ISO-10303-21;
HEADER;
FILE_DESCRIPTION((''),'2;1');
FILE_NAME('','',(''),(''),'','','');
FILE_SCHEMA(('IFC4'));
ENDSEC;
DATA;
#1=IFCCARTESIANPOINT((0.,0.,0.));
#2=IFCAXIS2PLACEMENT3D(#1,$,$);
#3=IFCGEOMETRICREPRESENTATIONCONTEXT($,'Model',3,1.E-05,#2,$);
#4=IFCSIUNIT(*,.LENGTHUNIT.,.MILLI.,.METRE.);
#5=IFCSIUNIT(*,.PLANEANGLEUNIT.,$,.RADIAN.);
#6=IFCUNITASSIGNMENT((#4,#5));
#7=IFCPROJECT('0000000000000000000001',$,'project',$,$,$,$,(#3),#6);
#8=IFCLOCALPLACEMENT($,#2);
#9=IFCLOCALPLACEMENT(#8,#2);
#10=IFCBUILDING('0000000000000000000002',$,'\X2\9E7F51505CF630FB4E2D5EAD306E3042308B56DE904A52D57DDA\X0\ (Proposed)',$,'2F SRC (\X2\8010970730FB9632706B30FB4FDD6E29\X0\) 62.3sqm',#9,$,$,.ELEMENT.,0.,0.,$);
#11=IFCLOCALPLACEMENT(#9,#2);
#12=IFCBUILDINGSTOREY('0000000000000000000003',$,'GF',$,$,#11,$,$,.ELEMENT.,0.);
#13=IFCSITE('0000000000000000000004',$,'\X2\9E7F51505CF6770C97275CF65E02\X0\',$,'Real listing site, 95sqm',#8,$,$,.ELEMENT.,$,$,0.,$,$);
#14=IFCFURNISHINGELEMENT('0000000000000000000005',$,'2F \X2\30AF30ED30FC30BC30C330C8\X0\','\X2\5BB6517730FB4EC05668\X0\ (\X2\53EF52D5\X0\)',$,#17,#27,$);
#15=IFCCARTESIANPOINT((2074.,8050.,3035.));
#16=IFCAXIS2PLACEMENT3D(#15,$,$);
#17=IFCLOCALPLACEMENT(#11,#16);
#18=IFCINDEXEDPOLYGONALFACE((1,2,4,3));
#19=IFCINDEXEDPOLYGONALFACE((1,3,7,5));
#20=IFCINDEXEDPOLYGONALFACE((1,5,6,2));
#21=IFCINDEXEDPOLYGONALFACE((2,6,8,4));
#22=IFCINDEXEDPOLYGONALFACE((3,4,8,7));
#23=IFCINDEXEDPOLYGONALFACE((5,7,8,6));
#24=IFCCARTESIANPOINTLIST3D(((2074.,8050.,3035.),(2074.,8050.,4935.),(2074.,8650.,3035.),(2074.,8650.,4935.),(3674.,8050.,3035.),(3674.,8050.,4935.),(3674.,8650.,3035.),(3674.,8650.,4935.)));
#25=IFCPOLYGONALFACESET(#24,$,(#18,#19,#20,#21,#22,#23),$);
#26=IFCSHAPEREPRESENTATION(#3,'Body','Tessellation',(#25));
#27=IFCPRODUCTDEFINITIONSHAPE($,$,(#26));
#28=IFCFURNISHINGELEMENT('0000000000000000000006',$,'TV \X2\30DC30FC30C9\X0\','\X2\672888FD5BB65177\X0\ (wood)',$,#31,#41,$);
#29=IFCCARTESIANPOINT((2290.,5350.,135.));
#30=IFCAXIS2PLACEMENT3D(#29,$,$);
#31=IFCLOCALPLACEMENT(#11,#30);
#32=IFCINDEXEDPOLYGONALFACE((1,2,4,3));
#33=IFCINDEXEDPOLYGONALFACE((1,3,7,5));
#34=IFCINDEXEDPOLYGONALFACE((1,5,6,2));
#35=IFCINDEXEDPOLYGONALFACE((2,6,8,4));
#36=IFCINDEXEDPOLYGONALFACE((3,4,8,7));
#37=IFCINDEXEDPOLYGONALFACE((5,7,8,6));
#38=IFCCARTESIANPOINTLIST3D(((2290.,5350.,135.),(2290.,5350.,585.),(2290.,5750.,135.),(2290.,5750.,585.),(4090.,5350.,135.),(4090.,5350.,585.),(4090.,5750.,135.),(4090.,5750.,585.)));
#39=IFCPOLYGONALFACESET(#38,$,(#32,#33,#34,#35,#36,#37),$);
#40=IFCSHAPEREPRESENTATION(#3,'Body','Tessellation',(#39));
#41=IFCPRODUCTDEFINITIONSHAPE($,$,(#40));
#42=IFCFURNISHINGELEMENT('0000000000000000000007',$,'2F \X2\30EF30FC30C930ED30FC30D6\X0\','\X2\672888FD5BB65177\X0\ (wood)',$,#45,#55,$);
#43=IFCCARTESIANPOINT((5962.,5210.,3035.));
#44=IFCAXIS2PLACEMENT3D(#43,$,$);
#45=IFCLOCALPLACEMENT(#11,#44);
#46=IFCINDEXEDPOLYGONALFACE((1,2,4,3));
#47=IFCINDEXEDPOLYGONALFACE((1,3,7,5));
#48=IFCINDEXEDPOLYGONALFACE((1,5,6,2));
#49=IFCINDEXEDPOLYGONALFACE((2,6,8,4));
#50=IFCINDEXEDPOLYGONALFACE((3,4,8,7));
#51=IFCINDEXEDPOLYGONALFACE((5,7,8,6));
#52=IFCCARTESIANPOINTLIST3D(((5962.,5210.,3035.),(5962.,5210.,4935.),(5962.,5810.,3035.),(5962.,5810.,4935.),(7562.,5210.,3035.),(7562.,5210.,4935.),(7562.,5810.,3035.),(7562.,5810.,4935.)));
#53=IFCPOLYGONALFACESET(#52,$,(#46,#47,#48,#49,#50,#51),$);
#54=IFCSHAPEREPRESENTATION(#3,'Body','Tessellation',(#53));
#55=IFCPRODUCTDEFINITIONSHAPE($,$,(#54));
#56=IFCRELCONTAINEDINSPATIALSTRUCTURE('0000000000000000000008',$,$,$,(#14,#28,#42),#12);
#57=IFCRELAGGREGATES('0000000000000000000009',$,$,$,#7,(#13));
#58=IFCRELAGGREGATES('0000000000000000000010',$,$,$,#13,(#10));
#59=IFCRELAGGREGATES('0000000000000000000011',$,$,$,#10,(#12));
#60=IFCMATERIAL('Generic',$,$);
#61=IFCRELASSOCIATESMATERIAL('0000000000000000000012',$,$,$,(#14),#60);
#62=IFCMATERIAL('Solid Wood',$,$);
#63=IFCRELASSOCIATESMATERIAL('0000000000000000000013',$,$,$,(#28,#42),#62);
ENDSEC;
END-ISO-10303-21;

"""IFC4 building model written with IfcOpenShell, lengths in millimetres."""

from ifc_helpers import new_model, si_unit, frame, frame_2d, origin, place, context, project, spatial, rectangle, extrude, material, element, save


model = new_model("IFC4")

# Units and contexts
model_context = context("Model", 3, precision=1e-05, world=origin())
ifc_project = project(units=[si_unit("LENGTHUNIT", "METRE", prefix="MILLI"), si_unit("PLANEANGLEUNIT", "RADIAN")], contexts=[model_context])

# Site, building, storey
site_placement = place(None, origin())
site = spatial("IfcSite", under=ifc_project, at=site_placement, Name="鹿児島県霧島市", ObjectType="Real listing site, 95sqm", CompositionType="ELEMENT", RefElevation=0.0)
building_placement = place(site_placement, origin())
building = spatial("IfcBuilding", under=site, at=building_placement, Name="鹿児島・中庭のある回遊動線 (Proposed)", ObjectType="2F SRC (耐震・防火・保温) 62.3sqm", CompositionType="ELEMENT", ElevationOfRefHeight=0.0, ElevationOfTerrain=0.0)
storey_placement = place(building_placement, origin())
storey = spatial("IfcBuildingStorey", under=building, at=storey_placement, Name="GF", CompositionType="ELEMENT", Elevation=0.0)

# Shared definitions
ifc_material_1 = material(Name="Solid Wood")

# Shared definitions
ifc_material_2 = material(Name="Generic")

# Furnishing elements
furnishing_1_placement = place(storey_placement, frame((2074.0, 8050.0, 3035.0)))
element("IfcFurnishingElement", 1, at=furnishing_1_placement, inside=storey, material=ifc_material_2, Name="2F クローゼット", Description="家具・什器 (可動)", context=model_context, shape_type="SweptSolid", body=[
    extrude(rectangle(XDim=1600.0, YDim=600.0, at=frame_2d((800.0, 300.0))), frame((2074.0, 8050.0, 3035.0)), (0.0, 0.0, 1.0), 1900.0),
])
furnishing_2_placement = place(storey_placement, frame((2290.0, 5350.0, 135.0)))
element("IfcFurnishingElement", 2, at=furnishing_2_placement, inside=storey, material=ifc_material_1, Name="TV ボード", Description="木製家具 (wood)", context=model_context, shape_type="SweptSolid", body=[
    extrude(rectangle(XDim=1800.0, YDim=400.0, at=frame_2d((900.0, 200.0))), frame((2290.0, 5350.0, 135.0)), (0.0, 0.0, 1.0), 450.0),
])
furnishing_3_placement = place(storey_placement, frame((5962.0, 5210.0, 3035.0)))
element("IfcFurnishingElement", 3, at=furnishing_3_placement, inside=storey, material=ifc_material_1, Name="2F ワードローブ", Description="木製家具 (wood)", context=model_context, shape_type="SweptSolid", body=[
    extrude(rectangle(XDim=1600.0, YDim=600.0, at=frame_2d((800.0, 300.0))), frame((5962.0, 5210.0, 3035.0)), (0.0, 0.0, 1.0), 1900.0),
])

save(model, "model.ifc")
